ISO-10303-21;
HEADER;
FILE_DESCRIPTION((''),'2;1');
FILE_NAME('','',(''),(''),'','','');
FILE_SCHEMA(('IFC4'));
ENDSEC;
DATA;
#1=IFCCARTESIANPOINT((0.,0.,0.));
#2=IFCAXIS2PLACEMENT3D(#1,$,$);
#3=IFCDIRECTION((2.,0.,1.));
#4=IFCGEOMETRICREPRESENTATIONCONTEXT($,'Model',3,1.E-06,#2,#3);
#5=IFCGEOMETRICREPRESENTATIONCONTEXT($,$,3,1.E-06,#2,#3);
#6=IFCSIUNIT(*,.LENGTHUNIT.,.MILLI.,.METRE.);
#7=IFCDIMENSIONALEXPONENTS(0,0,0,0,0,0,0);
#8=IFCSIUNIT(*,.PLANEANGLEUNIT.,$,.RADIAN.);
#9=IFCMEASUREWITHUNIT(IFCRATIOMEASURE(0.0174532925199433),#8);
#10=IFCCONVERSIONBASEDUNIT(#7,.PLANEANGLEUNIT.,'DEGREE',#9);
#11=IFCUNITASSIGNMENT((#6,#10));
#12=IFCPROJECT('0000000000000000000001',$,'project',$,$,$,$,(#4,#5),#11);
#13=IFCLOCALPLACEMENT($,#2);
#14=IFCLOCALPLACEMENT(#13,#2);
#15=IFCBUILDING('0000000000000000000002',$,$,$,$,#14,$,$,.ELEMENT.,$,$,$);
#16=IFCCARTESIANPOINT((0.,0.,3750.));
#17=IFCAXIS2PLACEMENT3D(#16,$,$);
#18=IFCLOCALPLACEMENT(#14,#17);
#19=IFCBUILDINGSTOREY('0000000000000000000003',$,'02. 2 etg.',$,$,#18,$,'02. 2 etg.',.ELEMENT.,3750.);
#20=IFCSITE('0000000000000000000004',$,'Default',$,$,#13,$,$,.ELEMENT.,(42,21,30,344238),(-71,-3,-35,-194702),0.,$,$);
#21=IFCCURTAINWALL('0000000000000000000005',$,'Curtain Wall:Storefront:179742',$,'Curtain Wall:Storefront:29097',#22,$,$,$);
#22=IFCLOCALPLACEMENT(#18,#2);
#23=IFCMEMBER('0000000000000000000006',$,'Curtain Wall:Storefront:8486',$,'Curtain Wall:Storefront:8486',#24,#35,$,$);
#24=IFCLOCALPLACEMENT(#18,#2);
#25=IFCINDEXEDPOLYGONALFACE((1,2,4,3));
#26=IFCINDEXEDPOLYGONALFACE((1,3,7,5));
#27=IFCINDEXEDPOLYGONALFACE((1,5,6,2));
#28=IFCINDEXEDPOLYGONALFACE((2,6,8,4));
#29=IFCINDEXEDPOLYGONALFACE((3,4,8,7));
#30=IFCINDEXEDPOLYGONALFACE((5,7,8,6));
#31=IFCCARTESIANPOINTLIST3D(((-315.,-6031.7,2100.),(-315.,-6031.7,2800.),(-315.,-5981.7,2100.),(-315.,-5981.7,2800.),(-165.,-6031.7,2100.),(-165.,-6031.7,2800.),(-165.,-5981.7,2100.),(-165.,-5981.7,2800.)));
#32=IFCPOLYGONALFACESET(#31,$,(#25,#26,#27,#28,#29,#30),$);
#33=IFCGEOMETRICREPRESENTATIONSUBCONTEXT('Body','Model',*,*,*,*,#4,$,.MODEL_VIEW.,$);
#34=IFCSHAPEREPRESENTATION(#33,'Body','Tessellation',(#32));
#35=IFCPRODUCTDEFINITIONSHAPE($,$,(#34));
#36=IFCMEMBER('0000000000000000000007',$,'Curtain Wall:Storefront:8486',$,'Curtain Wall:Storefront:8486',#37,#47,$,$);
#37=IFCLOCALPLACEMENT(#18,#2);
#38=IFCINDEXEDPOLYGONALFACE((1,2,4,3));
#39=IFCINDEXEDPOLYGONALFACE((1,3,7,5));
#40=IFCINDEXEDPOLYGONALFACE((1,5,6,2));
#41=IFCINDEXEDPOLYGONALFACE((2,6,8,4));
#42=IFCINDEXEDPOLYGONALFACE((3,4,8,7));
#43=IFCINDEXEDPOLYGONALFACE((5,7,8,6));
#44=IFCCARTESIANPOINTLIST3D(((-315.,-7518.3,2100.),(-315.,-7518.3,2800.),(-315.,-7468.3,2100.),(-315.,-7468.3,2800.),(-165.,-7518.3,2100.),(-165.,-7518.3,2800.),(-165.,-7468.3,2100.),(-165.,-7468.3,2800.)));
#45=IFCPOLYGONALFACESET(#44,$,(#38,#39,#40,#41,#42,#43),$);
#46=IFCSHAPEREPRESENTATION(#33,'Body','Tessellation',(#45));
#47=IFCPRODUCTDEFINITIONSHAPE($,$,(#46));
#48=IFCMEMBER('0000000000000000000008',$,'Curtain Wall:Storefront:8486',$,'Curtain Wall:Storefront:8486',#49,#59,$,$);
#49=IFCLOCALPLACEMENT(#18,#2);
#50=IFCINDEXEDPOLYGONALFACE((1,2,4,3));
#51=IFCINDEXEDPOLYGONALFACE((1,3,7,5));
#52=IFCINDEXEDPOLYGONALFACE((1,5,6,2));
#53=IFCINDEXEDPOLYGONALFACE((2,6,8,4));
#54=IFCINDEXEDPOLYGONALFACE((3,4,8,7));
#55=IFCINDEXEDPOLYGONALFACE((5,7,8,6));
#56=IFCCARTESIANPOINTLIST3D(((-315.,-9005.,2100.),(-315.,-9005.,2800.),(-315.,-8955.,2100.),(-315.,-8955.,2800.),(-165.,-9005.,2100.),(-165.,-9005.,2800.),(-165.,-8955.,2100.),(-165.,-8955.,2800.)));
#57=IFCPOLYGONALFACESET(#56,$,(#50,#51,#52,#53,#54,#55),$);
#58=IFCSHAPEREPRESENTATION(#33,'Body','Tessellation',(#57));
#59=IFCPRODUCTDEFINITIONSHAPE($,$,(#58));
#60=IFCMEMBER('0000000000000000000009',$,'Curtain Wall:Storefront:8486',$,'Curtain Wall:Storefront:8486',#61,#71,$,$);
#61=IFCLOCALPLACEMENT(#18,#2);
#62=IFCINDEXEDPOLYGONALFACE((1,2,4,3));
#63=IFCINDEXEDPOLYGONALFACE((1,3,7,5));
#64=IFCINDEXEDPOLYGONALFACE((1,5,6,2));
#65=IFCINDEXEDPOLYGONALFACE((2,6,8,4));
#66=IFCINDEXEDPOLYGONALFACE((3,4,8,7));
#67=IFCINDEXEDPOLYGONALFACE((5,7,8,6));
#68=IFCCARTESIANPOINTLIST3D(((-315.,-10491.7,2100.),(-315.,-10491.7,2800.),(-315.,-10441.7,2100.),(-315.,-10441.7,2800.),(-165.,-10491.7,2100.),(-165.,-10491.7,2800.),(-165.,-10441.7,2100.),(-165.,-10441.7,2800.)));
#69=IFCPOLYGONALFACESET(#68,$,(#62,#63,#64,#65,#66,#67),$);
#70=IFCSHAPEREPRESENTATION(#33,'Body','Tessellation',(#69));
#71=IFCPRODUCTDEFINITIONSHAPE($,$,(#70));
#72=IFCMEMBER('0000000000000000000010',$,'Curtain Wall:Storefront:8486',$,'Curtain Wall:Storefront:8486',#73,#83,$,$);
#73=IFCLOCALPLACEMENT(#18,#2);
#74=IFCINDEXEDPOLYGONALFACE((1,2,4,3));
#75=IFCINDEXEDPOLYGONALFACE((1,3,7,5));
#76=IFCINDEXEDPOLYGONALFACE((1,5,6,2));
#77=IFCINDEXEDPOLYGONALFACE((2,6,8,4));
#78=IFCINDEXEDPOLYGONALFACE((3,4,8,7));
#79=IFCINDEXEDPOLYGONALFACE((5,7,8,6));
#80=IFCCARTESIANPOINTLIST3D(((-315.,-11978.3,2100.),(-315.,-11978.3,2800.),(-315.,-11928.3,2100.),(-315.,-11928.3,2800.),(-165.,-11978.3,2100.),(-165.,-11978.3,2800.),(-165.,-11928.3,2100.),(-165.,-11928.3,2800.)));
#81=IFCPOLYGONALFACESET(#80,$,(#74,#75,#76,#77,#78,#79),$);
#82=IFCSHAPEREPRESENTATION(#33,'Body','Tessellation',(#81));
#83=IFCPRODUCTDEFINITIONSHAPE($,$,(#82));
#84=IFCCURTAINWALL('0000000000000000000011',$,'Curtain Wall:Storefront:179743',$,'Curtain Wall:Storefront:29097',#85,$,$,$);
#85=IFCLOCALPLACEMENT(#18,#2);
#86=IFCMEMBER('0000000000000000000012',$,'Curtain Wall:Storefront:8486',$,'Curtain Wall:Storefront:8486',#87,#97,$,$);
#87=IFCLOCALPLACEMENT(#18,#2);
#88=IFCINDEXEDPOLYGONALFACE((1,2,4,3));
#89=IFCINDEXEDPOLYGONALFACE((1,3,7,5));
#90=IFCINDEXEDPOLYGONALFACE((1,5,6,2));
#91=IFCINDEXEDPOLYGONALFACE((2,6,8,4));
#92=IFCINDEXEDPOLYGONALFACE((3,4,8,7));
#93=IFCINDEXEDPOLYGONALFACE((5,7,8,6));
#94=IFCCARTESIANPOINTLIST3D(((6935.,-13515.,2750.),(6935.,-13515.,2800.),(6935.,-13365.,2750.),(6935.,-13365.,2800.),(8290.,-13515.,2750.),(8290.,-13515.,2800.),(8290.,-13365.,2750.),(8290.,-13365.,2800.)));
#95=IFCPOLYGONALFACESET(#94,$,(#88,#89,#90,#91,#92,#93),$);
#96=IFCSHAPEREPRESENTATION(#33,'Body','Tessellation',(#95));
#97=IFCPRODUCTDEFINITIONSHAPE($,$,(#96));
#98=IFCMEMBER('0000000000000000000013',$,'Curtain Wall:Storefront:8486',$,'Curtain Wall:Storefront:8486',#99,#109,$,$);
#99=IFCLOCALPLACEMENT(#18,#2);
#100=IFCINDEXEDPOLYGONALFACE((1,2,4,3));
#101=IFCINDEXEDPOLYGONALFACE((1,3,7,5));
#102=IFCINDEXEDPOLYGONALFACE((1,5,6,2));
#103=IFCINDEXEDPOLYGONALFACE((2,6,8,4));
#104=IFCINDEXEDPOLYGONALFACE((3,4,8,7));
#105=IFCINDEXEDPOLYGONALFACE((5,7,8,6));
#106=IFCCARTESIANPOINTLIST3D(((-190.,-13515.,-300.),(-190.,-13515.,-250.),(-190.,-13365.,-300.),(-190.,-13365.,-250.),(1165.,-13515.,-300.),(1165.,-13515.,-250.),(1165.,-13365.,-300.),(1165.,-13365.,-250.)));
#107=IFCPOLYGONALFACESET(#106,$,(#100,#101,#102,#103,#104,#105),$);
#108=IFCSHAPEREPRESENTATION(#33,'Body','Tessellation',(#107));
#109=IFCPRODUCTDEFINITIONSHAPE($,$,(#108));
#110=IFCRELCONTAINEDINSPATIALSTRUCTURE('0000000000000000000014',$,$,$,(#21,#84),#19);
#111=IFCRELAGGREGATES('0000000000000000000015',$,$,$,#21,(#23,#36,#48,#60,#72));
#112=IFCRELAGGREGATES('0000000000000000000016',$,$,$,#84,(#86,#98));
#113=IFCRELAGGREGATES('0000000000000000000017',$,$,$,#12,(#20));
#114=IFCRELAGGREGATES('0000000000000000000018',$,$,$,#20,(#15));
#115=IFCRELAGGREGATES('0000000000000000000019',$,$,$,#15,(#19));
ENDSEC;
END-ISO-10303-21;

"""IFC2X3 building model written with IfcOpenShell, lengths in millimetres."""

from ifc_helpers import new_model, entity, si_unit, converted_unit, direction, frame, frame_2d, origin, origin_2d_with_axis, place, context, subcontext, project, spatial, rectangle, extrude, element, aggregate, save


model = new_model("IFC2X3")

# Units and contexts
model_context = context("Model", 3, precision=1e-06, world=origin(), true_north=direction((2.0, 0.0, 1.0)))
context_of_model = context(None, 3, precision=1e-06, world=origin(), true_north=direction((2.0, 0.0, 1.0)))
body_context = subcontext(model_context, "Body", "Model", "MODEL_VIEW")
ifc_project = project(units=[si_unit("LENGTHUNIT", "METRE", prefix="MILLI"), converted_unit("PLANEANGLEUNIT", "DEGREE", entity("IfcRatioMeasure", 0.0174532925199433), si_unit("PLANEANGLEUNIT", "RADIAN"), dimensions=[0, 0, 0, 0, 0, 0, 0])], contexts=[model_context, context_of_model])

# Site, building, storey
site_placement = place(None, origin())
site = spatial("IfcSite", under=ifc_project, at=site_placement, Name="Default", CompositionType="ELEMENT", RefLatitude=(42, 21, 30, 344238), RefLongitude=(-71, -3, -35, -194702), RefElevation=0.0)
building_placement = place(site_placement, origin())
building = spatial("IfcBuilding", under=site, at=building_placement, CompositionType="ELEMENT")
storey_placement = place(building_placement, frame((0.0, 0.0, 3750.0)))
storey = spatial("IfcBuildingStorey", under=building, at=storey_placement, Name="02. 2 etg.", LongName="02. 2 etg.", CompositionType="ELEMENT", Elevation=3750.0)

# Curtain walls, members
curtain_wall_1_placement = place(storey_placement, origin())
curtain_wall_1 = element("IfcCurtainWall", 1, at=curtain_wall_1_placement, inside=storey, Name="Curtain Wall:Storefront:179742", ObjectType="Curtain Wall:Storefront:29097")
member_1_placement = place(storey_placement, origin())
member_1 = element("IfcMember", 2, at=member_1_placement, Name="Curtain Wall:Storefront:8486", ObjectType="Curtain Wall:Storefront:8486", context=body_context, shape_type="SweptSolid", body=[
    extrude(rectangle(XDim=150.0, YDim=50.0, at=frame_2d((0.0, 0.0), x_axis=(1.0, 0.0))), frame((-240.0, -6006.7, 2100.0)), (0.0, 0.0, 1.0), 700.0),
])
member_2_placement = place(storey_placement, origin())
member_2 = element("IfcMember", 3, at=member_2_placement, Name="Curtain Wall:Storefront:8486", ObjectType="Curtain Wall:Storefront:8486", context=body_context, shape_type="SweptSolid", body=[
    extrude(rectangle(XDim=150.0, YDim=50.0, at=frame_2d((0.0, 0.0), x_axis=(1.0, 0.0))), frame((-240.0, -7493.3, 2100.0)), (0.0, 0.0, 1.0), 700.0),
])
member_3_placement = place(storey_placement, origin())
member_3 = element("IfcMember", 4, at=member_3_placement, Name="Curtain Wall:Storefront:8486", ObjectType="Curtain Wall:Storefront:8486", context=body_context, shape_type="SweptSolid", body=[
    extrude(rectangle(XDim=150.0, YDim=50.0, at=frame_2d((0.0, 0.0), x_axis=(1.0, 0.0))), frame((-240.0, -8980.0, 2100.0)), (0.0, 0.0, 1.0), 700.0),
])
member_4_placement = place(storey_placement, origin())
member_4 = element("IfcMember", 5, at=member_4_placement, Name="Curtain Wall:Storefront:8486", ObjectType="Curtain Wall:Storefront:8486", context=body_context, shape_type="SweptSolid", body=[
    extrude(rectangle(XDim=150.0, YDim=50.0, at=frame_2d((0.0, 0.0), x_axis=(1.0, 0.0))), frame((-240.0, -10466.7, 2100.0)), (0.0, 0.0, 1.0), 700.0),
])
member_5_placement = place(storey_placement, origin())
member_5 = element("IfcMember", 6, at=member_5_placement, Name="Curtain Wall:Storefront:8486", ObjectType="Curtain Wall:Storefront:8486", context=body_context, shape_type="SweptSolid", body=[
    extrude(rectangle(XDim=150.0, YDim=50.0, at=frame_2d((0.0, 0.0), x_axis=(1.0, 0.0))), frame((-240.0, -11953.3, 2100.0)), (0.0, 0.0, 1.0), 700.0),
])
aggregate(curtain_wall_1, [member_1, member_2, member_3, member_4, member_5])
curtain_wall_2_placement = place(storey_placement, origin())
curtain_wall_2 = element("IfcCurtainWall", 7, at=curtain_wall_2_placement, inside=storey, Name="Curtain Wall:Storefront:179743", ObjectType="Curtain Wall:Storefront:29097")
member_6_placement = place(storey_placement, origin())
member_6 = element("IfcMember", 8, at=member_6_placement, Name="Curtain Wall:Storefront:8486", ObjectType="Curtain Wall:Storefront:8486", context=body_context, shape_type="SweptSolid", body=[
    extrude(rectangle(XDim=1355.0, YDim=150.0, at=origin_2d_with_axis()), frame((7612.5, -13440.0, 2750.0), z_axis=(0.0, 0.0, 1.0), x_axis=(-1.0, 0.0, 0.0)), (0.0, 0.0, 1.0), 50.0),
])
member_7_placement = place(storey_placement, origin())
member_7 = element("IfcMember", 9, at=member_7_placement, Name="Curtain Wall:Storefront:8486", ObjectType="Curtain Wall:Storefront:8486", context=body_context, shape_type="SweptSolid", body=[
    extrude(rectangle(XDim=1355.0, YDim=150.0, at=frame_2d((0.0, 0.0), x_axis=(1.0, 0.0))), frame((487.5, -13440.0, -300.0)), (0.0, 0.0, 1.0), 50.0),
])
aggregate(curtain_wall_2, [member_6, member_7])

save(model, "model.ifc")
